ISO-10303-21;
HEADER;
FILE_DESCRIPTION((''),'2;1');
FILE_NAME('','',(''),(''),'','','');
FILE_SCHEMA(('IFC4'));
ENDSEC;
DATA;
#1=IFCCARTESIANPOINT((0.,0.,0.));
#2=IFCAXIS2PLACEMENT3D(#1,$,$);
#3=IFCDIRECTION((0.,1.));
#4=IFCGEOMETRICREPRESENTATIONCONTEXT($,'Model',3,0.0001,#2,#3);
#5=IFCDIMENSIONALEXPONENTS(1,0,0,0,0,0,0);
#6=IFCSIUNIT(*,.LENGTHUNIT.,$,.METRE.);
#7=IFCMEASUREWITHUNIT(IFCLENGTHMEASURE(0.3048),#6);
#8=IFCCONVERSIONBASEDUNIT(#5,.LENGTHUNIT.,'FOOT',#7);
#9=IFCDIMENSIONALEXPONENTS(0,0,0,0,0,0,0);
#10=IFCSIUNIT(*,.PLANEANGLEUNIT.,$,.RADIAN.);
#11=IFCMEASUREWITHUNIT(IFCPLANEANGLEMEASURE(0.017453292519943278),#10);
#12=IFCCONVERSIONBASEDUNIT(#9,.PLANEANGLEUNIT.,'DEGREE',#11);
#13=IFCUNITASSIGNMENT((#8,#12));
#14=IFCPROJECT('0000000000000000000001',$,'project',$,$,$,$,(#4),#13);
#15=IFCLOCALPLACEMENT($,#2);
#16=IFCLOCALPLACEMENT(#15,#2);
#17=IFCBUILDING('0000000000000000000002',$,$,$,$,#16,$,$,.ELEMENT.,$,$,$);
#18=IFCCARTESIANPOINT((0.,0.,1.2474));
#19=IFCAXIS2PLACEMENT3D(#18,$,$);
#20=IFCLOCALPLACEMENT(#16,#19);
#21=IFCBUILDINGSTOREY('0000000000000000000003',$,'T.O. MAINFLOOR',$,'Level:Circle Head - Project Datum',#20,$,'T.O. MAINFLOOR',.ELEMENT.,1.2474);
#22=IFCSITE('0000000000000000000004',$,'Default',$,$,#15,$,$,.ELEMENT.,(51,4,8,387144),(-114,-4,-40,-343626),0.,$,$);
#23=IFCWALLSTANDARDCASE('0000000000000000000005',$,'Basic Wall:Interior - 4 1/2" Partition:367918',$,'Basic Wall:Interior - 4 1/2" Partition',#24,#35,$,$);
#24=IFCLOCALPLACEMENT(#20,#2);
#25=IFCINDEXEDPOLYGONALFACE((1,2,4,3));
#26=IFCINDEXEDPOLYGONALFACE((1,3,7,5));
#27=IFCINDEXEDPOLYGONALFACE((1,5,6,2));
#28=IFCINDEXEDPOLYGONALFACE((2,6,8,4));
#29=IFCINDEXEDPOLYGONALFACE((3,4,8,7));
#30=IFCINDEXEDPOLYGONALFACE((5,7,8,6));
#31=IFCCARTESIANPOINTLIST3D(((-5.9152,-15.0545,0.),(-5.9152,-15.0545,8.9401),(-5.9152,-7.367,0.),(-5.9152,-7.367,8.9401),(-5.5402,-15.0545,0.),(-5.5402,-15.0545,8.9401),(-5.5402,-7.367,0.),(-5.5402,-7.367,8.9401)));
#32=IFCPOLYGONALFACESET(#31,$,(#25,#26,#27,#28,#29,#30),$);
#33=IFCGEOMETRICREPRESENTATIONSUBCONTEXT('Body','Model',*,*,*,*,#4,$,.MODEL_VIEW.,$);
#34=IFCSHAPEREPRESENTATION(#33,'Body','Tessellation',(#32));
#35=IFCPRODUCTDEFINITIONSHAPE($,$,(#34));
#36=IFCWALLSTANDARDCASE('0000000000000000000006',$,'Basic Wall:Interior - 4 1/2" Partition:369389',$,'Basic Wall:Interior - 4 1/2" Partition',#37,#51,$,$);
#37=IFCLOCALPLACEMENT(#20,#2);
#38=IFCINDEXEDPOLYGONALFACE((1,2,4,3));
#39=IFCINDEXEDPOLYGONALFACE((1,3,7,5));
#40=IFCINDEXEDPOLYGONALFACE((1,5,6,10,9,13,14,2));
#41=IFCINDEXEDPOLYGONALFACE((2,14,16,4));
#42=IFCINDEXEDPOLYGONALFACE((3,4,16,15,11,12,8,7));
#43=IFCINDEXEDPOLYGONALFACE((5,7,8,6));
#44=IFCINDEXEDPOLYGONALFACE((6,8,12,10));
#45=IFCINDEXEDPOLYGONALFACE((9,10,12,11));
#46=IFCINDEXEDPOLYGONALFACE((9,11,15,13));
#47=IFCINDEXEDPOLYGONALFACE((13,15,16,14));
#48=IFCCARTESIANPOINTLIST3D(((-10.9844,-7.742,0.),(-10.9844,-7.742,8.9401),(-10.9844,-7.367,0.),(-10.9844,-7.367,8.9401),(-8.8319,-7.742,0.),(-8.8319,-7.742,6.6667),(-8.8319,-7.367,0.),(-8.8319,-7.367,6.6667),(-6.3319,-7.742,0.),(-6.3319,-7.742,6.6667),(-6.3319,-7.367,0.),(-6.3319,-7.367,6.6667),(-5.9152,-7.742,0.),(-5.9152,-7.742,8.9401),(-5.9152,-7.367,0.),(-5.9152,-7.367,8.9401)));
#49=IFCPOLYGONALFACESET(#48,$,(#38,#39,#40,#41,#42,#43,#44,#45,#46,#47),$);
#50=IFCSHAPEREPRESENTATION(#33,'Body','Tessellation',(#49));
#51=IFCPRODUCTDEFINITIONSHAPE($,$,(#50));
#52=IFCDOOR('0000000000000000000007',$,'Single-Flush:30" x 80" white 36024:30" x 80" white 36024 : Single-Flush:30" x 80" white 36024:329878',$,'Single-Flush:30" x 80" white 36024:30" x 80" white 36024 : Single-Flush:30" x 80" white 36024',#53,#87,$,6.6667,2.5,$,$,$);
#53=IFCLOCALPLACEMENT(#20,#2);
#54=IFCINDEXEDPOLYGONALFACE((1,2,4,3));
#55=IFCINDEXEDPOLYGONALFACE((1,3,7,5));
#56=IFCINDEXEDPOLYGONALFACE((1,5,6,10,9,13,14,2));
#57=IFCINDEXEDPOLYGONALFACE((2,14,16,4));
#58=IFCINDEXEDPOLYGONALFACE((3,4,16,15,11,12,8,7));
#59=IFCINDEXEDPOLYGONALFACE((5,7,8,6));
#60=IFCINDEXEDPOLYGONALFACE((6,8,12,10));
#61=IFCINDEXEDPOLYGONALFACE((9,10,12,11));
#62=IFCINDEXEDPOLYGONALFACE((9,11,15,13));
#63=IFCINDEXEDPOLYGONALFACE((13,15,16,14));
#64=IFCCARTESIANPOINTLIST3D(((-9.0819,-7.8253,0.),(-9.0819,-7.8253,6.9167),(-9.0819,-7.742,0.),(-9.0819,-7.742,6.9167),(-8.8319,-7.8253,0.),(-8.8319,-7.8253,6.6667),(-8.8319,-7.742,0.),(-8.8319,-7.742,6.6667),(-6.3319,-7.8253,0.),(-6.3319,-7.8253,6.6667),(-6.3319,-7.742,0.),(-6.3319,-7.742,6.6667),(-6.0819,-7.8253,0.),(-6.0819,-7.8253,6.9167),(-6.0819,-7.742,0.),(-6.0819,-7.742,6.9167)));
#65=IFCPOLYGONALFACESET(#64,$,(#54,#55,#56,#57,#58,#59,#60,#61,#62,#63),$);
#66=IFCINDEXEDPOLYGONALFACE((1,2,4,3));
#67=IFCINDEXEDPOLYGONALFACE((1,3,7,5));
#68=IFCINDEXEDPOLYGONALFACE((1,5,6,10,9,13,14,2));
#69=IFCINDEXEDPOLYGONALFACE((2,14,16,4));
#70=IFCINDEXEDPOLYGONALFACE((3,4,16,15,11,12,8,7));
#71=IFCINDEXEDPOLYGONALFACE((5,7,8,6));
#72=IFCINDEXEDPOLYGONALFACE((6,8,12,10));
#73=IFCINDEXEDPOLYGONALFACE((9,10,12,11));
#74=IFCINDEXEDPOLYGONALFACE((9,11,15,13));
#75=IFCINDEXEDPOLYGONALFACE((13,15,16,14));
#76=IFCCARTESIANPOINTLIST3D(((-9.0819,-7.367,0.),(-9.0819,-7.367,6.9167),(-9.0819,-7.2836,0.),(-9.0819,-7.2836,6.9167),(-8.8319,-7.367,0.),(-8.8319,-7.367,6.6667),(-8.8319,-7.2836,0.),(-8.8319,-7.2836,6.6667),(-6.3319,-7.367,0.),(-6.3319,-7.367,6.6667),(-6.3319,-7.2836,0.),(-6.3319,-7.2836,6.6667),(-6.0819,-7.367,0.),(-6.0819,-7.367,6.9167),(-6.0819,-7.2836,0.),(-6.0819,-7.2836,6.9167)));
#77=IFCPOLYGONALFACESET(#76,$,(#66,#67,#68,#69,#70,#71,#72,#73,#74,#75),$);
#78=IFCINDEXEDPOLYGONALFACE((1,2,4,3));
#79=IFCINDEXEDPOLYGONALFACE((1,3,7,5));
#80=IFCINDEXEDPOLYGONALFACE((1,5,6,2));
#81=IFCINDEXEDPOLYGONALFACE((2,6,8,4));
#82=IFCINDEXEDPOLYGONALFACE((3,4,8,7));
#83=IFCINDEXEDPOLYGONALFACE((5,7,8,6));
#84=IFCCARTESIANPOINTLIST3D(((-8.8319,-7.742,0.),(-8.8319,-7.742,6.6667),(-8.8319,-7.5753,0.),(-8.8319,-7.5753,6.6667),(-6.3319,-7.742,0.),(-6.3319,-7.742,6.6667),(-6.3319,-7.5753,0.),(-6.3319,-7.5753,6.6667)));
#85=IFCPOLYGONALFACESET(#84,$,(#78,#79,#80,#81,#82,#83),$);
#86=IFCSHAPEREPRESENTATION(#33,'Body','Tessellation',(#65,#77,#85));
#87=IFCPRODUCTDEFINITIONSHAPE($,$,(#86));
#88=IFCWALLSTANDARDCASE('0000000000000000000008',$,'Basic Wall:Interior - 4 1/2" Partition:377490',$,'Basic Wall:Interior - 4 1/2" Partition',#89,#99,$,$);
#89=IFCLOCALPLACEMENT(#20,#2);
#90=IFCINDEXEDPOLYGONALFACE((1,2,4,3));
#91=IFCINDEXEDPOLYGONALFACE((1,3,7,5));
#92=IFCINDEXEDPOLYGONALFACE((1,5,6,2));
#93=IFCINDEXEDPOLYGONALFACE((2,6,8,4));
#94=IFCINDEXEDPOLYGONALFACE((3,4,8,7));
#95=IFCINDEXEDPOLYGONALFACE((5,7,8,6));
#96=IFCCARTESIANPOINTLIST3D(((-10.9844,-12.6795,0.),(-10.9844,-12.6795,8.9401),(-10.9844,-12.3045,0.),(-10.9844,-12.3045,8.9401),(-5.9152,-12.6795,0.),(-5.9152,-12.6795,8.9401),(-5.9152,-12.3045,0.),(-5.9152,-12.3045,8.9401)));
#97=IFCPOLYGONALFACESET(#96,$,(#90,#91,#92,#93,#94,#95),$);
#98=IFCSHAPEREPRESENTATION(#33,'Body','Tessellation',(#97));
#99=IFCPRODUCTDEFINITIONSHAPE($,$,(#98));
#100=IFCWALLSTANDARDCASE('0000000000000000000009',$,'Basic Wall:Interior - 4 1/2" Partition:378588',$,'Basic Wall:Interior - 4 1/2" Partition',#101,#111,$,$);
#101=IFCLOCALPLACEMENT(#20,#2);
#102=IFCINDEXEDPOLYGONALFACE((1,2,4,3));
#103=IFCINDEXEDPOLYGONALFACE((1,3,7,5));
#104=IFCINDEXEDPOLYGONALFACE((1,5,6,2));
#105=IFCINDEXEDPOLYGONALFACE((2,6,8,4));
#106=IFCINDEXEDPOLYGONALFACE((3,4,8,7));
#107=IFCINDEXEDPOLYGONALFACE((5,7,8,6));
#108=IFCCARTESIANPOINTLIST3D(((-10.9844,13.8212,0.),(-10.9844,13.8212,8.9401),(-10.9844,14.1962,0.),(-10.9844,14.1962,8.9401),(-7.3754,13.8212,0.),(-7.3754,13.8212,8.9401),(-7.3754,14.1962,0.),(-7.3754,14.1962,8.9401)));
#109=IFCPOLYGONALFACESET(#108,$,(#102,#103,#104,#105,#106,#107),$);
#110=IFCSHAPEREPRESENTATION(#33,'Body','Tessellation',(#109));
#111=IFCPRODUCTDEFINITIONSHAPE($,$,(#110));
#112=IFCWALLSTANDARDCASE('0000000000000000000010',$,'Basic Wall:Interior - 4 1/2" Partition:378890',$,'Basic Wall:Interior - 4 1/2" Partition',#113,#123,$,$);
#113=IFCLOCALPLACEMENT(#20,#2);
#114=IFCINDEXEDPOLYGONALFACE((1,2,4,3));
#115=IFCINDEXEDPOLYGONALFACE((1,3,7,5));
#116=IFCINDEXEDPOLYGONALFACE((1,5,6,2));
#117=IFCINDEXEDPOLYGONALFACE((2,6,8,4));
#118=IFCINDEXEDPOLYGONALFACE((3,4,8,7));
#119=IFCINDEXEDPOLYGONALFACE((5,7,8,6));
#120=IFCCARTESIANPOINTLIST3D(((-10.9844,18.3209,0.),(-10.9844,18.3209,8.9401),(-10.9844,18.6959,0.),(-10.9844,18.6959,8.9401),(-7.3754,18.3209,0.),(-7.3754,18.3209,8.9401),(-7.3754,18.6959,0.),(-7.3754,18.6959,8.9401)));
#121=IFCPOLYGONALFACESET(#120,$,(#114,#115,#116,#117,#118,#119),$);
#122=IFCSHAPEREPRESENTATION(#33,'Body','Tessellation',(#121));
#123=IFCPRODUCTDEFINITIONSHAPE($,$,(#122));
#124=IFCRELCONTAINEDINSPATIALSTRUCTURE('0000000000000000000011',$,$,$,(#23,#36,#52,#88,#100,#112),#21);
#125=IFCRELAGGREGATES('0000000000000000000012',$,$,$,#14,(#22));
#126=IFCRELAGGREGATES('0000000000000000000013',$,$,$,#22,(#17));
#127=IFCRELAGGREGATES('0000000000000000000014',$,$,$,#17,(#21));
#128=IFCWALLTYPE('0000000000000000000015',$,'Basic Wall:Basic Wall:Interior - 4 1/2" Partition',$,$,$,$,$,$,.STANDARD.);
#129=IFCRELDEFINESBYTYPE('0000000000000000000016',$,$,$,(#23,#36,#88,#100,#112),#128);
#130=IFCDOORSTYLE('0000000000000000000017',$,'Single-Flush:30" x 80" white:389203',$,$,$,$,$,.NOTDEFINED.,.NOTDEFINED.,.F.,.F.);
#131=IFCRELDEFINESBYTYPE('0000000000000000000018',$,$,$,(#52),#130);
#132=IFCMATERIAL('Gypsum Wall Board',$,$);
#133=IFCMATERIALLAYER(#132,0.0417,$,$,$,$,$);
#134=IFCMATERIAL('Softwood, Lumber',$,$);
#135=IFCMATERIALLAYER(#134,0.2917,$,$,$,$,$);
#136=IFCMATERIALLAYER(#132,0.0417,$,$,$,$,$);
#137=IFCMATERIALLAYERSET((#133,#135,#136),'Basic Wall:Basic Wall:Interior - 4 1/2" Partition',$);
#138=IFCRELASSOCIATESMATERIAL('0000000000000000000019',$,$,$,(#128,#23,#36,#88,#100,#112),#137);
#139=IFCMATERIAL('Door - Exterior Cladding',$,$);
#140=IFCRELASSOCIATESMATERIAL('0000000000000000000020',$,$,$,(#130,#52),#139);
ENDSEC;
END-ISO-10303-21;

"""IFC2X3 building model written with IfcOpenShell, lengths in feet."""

from ifc_helpers import new_model, entity, si_unit, converted_unit, direction, frame, frame_2d, origin, origin_2d_with_axis, place, context, subcontext, project, spatial, polyline, rectangle, outline, extrude, source, transform, mapped, material, layer, layer_set, layer_usage, type_object, type_shapes, element, fill, save


model = new_model("IFC2X3")

# Units and contexts
model_context = context("Model", 3, precision=0.0001, world=origin(), true_north=direction((0.0, 1.0)))
body_context = subcontext(model_context, "Body", "Model", "MODEL_VIEW")
ifc_project = project(units=[converted_unit("LENGTHUNIT", "FOOT", entity("IfcLengthMeasure", 0.3048), si_unit("LENGTHUNIT", "METRE"), dimensions=[1, 0, 0, 0, 0, 0, 0]), converted_unit("PLANEANGLEUNIT", "DEGREE", entity("IfcPlaneAngleMeasure", 0.017453292519943278), si_unit("PLANEANGLEUNIT", "RADIAN"), dimensions=[0, 0, 0, 0, 0, 0, 0])], contexts=[model_context])

# Site, building, storey
site_placement = place(None, origin())
site = spatial("IfcSite", under=ifc_project, at=site_placement, Name="Default", CompositionType="ELEMENT", RefLatitude=(51, 4, 8, 387144), RefLongitude=(-114, -4, -40, -343626), RefElevation=0.0)
building_placement = place(site_placement, origin())
building = spatial("IfcBuilding", under=site, at=building_placement, CompositionType="ELEMENT")
storey_placement = place(building_placement, frame((0.0, 0.0, 1.2474)))
storey = spatial("IfcBuildingStorey", under=building, at=storey_placement, Name="T.O. MAINFLOOR", ObjectType="Level:Circle Head - Project Datum", LongName="T.O. MAINFLOOR", CompositionType="ELEMENT", Elevation=1.2474)

# Shared definitions
ifc_material_1 = material(Name="Gypsum Wall Board")

# Shared definitions
ifc_material_2 = material(Name="Door - Exterior Cladding")

# Wall
ifc_layer_1 = layer(ifc_material_1, 0.0417)
ifc_material_3 = material(Name="Softwood, Lumber")
ifc_layer_2 = layer(ifc_material_3, 0.2917)
ifc_layer_3 = layer(ifc_material_1, 0.0417)
ifc_layer_set_1 = layer_set([ifc_layer_1, ifc_layer_2, ifc_layer_3], Name="Basic Wall:Basic Wall:Interior - 4 1/2\" Partition")
ifc_layer_usage_1 = layer_usage(ifc_layer_set_1, "AXIS2", "NEGATIVE", 0.1875)
wall_type_1 = type_object("IfcWallType", Name="Basic Wall:Basic Wall:Interior - 4 1/2\" Partition", PredefinedType="STANDARD", material=ifc_layer_set_1)
wall_1_placement = place(storey_placement, frame((-5.7277, -15.0545, 0.0), z_axis=(0.0, 0.0, 1.0), x_axis=(0.0, 1.0, 0.0)))
element("IfcWallStandardCase", 1, at=wall_1_placement, inside=storey, type_object=wall_type_1, material=ifc_layer_usage_1, Name="Basic Wall:Interior - 4 1/2\" Partition:367918", ObjectType="Basic Wall:Interior - 4 1/2\" Partition", context=body_context, shape_type="SweptSolid", body=[
    extrude(rectangle(XDim=7.6875, YDim=0.375, at=frame_2d((3.8438, 0.0), x_axis=(-1.0, 0.0))), origin(), (0.0, 0.0, 1.0), 8.9401),
])

# Wall, opening, door
ifc_layer_usage_2 = layer_usage(ifc_layer_set_1, "AXIS2", "NEGATIVE", 0.1875)
wall_2_placement = place(storey_placement, frame((-10.9844, -7.5545, 0.0)))
wall_2 = element("IfcWallStandardCase", 2, at=wall_2_placement, inside=storey, type_object=wall_type_1, material=ifc_layer_usage_2, Name="Basic Wall:Interior - 4 1/2\" Partition:369389", ObjectType="Basic Wall:Interior - 4 1/2\" Partition", context=body_context, shape_type="SweptSolid", body=[
    extrude(rectangle(XDim=5.0692, YDim=0.375, at=frame_2d((2.5346, 0.0), x_axis=(1.0, 0.0))), origin(), (0.0, 0.0, 1.0), 8.9401),
])
opening_1_placement = place(wall_2_placement, frame((10.9844, 7.5545, 0.0)))
opening_1 = element("IfcOpeningElement", 3, at=opening_1_placement, cuts=wall_2, ObjectType="Opening", context=body_context, shape_type="SweptSolid", body=[
    extrude(rectangle(XDim=6.6667, YDim=2.5, at=frame_2d((0.0, 0.0), x_axis=(0.0, 1.0))), frame((-7.5819, -7.7457, 3.3333), z_axis=(0.0, 1.0, 0.0), x_axis=(-1.0, 0.0, 0.0)), (0.0, 0.0, 1.0), 0.3825),
])
door_style_1 = type_object("IfcDoorStyle", Name="Single-Flush:30\" x 80\" white:389203", ConstructionType="NOTDEFINED", OperationType="NOTDEFINED", ParameterTakesPrecedence=False, Sizeable=False, material=ifc_material_2)
shared_shape_1 = source(origin(), body_context, "Body", "SweptSolid", [
    extrude(outline(polyline([(-1.5, -3.5208), (1.5, -3.5208), (1.5, 3.3958), (1.25, 3.3958), (1.25, -3.2708), (-1.25, -3.2708), (-1.25, 3.3958), (-1.5, 3.3958), (-1.5, -3.5208)])), frame((1.25, 0.3787, 3.3958), z_axis=(0.0, 1.0, 0.0), x_axis=(1.0, 0.0, 0.0)), (0.0, 0.0, 1.0), 0.0833),
    extrude(outline(polyline([(-3.3958, -1.5), (3.5208, -1.5), (3.5208, 1.5), (-3.3958, 1.5), (-3.3958, 1.25), (3.2708, 1.25), (3.2708, -1.25), (-3.3958, -1.25), (-3.3958, -1.5)])), frame((1.25, -0.0796, 3.3958), z_axis=(0.0, 1.0, 0.0), x_axis=(0.0, 0.0, 1.0)), (0.0, 0.0, 1.0), 0.0833),
    extrude(rectangle(XDim=0.1667, YDim=2.5, at=origin_2d_with_axis()), frame((1.25, 0.2954, 0.0), z_axis=(0.0, 0.0, 1.0), x_axis=(0.0, 1.0, 0.0)), (0.0, 0.0, 1.0), 6.6667),
])
type_shapes(door_style_1, [shared_shape_1])
door_1_placement = place(opening_1_placement, frame((-6.3319, -7.3632, 0.0), z_axis=(0.0, 0.0, 1.0), x_axis=(-1.0, 0.0, 0.0)))
door_1 = element("IfcDoor", 4, at=door_1_placement, inside=storey, type_object=door_style_1, material=ifc_material_2, Name="Single-Flush:30\" x 80\" white 36024:30\" x 80\" white 36024 : Single-Flush:30\" x 80\" white 36024:329878", ObjectType="Single-Flush:30\" x 80\" white 36024:30\" x 80\" white 36024 : Single-Flush:30\" x 80\" white 36024", OverallHeight=6.6667, OverallWidth=2.5, context=body_context, shape_type="MappedRepresentation", body=[
    mapped(shared_shape_1, transform((0.0, 0.0, 0.0), scale=1.0)),
])
fill(opening_1, door_1)

# Walls
ifc_layer_usage_3 = layer_usage(ifc_layer_set_1, "AXIS2", "NEGATIVE", 0.1875)
wall_3_placement = place(storey_placement, frame((-10.9844, -12.492, 0.0)))
element("IfcWallStandardCase", 5, at=wall_3_placement, inside=storey, type_object=wall_type_1, material=ifc_layer_usage_3, Name="Basic Wall:Interior - 4 1/2\" Partition:377490", ObjectType="Basic Wall:Interior - 4 1/2\" Partition", context=body_context, shape_type="SweptSolid", body=[
    extrude(rectangle(XDim=5.0692, YDim=0.375, at=frame_2d((2.5346, 0.0), x_axis=(-1.0, 0.0))), origin(), (0.0, 0.0, 1.0), 8.9401),
])
ifc_layer_usage_4 = layer_usage(ifc_layer_set_1, "AXIS2", "NEGATIVE", 0.1875)
wall_4_placement = place(storey_placement, frame((-10.9844, 14.0087, 0.0)))
element("IfcWallStandardCase", 6, at=wall_4_placement, inside=storey, type_object=wall_type_1, material=ifc_layer_usage_4, Name="Basic Wall:Interior - 4 1/2\" Partition:378588", ObjectType="Basic Wall:Interior - 4 1/2\" Partition", context=body_context, shape_type="SweptSolid", body=[
    extrude(rectangle(XDim=3.609, YDim=0.375, at=frame_2d((1.8045, 0.0), x_axis=(-1.0, 0.0))), origin(), (0.0, 0.0, 1.0), 8.9401),
])
ifc_layer_usage_5 = layer_usage(ifc_layer_set_1, "AXIS2", "NEGATIVE", 0.1875)
wall_5_placement = place(storey_placement, frame((-10.9844, 18.5084, 0.0)))
element("IfcWallStandardCase", 7, at=wall_5_placement, inside=storey, type_object=wall_type_1, material=ifc_layer_usage_5, Name="Basic Wall:Interior - 4 1/2\" Partition:378890", ObjectType="Basic Wall:Interior - 4 1/2\" Partition", context=body_context, shape_type="SweptSolid", body=[
    extrude(rectangle(XDim=3.609, YDim=0.375, at=frame_2d((1.8045, 0.0), x_axis=(-1.0, 0.0))), origin(), (0.0, 0.0, 1.0), 8.9401),
])

save(model, "model.ifc")
